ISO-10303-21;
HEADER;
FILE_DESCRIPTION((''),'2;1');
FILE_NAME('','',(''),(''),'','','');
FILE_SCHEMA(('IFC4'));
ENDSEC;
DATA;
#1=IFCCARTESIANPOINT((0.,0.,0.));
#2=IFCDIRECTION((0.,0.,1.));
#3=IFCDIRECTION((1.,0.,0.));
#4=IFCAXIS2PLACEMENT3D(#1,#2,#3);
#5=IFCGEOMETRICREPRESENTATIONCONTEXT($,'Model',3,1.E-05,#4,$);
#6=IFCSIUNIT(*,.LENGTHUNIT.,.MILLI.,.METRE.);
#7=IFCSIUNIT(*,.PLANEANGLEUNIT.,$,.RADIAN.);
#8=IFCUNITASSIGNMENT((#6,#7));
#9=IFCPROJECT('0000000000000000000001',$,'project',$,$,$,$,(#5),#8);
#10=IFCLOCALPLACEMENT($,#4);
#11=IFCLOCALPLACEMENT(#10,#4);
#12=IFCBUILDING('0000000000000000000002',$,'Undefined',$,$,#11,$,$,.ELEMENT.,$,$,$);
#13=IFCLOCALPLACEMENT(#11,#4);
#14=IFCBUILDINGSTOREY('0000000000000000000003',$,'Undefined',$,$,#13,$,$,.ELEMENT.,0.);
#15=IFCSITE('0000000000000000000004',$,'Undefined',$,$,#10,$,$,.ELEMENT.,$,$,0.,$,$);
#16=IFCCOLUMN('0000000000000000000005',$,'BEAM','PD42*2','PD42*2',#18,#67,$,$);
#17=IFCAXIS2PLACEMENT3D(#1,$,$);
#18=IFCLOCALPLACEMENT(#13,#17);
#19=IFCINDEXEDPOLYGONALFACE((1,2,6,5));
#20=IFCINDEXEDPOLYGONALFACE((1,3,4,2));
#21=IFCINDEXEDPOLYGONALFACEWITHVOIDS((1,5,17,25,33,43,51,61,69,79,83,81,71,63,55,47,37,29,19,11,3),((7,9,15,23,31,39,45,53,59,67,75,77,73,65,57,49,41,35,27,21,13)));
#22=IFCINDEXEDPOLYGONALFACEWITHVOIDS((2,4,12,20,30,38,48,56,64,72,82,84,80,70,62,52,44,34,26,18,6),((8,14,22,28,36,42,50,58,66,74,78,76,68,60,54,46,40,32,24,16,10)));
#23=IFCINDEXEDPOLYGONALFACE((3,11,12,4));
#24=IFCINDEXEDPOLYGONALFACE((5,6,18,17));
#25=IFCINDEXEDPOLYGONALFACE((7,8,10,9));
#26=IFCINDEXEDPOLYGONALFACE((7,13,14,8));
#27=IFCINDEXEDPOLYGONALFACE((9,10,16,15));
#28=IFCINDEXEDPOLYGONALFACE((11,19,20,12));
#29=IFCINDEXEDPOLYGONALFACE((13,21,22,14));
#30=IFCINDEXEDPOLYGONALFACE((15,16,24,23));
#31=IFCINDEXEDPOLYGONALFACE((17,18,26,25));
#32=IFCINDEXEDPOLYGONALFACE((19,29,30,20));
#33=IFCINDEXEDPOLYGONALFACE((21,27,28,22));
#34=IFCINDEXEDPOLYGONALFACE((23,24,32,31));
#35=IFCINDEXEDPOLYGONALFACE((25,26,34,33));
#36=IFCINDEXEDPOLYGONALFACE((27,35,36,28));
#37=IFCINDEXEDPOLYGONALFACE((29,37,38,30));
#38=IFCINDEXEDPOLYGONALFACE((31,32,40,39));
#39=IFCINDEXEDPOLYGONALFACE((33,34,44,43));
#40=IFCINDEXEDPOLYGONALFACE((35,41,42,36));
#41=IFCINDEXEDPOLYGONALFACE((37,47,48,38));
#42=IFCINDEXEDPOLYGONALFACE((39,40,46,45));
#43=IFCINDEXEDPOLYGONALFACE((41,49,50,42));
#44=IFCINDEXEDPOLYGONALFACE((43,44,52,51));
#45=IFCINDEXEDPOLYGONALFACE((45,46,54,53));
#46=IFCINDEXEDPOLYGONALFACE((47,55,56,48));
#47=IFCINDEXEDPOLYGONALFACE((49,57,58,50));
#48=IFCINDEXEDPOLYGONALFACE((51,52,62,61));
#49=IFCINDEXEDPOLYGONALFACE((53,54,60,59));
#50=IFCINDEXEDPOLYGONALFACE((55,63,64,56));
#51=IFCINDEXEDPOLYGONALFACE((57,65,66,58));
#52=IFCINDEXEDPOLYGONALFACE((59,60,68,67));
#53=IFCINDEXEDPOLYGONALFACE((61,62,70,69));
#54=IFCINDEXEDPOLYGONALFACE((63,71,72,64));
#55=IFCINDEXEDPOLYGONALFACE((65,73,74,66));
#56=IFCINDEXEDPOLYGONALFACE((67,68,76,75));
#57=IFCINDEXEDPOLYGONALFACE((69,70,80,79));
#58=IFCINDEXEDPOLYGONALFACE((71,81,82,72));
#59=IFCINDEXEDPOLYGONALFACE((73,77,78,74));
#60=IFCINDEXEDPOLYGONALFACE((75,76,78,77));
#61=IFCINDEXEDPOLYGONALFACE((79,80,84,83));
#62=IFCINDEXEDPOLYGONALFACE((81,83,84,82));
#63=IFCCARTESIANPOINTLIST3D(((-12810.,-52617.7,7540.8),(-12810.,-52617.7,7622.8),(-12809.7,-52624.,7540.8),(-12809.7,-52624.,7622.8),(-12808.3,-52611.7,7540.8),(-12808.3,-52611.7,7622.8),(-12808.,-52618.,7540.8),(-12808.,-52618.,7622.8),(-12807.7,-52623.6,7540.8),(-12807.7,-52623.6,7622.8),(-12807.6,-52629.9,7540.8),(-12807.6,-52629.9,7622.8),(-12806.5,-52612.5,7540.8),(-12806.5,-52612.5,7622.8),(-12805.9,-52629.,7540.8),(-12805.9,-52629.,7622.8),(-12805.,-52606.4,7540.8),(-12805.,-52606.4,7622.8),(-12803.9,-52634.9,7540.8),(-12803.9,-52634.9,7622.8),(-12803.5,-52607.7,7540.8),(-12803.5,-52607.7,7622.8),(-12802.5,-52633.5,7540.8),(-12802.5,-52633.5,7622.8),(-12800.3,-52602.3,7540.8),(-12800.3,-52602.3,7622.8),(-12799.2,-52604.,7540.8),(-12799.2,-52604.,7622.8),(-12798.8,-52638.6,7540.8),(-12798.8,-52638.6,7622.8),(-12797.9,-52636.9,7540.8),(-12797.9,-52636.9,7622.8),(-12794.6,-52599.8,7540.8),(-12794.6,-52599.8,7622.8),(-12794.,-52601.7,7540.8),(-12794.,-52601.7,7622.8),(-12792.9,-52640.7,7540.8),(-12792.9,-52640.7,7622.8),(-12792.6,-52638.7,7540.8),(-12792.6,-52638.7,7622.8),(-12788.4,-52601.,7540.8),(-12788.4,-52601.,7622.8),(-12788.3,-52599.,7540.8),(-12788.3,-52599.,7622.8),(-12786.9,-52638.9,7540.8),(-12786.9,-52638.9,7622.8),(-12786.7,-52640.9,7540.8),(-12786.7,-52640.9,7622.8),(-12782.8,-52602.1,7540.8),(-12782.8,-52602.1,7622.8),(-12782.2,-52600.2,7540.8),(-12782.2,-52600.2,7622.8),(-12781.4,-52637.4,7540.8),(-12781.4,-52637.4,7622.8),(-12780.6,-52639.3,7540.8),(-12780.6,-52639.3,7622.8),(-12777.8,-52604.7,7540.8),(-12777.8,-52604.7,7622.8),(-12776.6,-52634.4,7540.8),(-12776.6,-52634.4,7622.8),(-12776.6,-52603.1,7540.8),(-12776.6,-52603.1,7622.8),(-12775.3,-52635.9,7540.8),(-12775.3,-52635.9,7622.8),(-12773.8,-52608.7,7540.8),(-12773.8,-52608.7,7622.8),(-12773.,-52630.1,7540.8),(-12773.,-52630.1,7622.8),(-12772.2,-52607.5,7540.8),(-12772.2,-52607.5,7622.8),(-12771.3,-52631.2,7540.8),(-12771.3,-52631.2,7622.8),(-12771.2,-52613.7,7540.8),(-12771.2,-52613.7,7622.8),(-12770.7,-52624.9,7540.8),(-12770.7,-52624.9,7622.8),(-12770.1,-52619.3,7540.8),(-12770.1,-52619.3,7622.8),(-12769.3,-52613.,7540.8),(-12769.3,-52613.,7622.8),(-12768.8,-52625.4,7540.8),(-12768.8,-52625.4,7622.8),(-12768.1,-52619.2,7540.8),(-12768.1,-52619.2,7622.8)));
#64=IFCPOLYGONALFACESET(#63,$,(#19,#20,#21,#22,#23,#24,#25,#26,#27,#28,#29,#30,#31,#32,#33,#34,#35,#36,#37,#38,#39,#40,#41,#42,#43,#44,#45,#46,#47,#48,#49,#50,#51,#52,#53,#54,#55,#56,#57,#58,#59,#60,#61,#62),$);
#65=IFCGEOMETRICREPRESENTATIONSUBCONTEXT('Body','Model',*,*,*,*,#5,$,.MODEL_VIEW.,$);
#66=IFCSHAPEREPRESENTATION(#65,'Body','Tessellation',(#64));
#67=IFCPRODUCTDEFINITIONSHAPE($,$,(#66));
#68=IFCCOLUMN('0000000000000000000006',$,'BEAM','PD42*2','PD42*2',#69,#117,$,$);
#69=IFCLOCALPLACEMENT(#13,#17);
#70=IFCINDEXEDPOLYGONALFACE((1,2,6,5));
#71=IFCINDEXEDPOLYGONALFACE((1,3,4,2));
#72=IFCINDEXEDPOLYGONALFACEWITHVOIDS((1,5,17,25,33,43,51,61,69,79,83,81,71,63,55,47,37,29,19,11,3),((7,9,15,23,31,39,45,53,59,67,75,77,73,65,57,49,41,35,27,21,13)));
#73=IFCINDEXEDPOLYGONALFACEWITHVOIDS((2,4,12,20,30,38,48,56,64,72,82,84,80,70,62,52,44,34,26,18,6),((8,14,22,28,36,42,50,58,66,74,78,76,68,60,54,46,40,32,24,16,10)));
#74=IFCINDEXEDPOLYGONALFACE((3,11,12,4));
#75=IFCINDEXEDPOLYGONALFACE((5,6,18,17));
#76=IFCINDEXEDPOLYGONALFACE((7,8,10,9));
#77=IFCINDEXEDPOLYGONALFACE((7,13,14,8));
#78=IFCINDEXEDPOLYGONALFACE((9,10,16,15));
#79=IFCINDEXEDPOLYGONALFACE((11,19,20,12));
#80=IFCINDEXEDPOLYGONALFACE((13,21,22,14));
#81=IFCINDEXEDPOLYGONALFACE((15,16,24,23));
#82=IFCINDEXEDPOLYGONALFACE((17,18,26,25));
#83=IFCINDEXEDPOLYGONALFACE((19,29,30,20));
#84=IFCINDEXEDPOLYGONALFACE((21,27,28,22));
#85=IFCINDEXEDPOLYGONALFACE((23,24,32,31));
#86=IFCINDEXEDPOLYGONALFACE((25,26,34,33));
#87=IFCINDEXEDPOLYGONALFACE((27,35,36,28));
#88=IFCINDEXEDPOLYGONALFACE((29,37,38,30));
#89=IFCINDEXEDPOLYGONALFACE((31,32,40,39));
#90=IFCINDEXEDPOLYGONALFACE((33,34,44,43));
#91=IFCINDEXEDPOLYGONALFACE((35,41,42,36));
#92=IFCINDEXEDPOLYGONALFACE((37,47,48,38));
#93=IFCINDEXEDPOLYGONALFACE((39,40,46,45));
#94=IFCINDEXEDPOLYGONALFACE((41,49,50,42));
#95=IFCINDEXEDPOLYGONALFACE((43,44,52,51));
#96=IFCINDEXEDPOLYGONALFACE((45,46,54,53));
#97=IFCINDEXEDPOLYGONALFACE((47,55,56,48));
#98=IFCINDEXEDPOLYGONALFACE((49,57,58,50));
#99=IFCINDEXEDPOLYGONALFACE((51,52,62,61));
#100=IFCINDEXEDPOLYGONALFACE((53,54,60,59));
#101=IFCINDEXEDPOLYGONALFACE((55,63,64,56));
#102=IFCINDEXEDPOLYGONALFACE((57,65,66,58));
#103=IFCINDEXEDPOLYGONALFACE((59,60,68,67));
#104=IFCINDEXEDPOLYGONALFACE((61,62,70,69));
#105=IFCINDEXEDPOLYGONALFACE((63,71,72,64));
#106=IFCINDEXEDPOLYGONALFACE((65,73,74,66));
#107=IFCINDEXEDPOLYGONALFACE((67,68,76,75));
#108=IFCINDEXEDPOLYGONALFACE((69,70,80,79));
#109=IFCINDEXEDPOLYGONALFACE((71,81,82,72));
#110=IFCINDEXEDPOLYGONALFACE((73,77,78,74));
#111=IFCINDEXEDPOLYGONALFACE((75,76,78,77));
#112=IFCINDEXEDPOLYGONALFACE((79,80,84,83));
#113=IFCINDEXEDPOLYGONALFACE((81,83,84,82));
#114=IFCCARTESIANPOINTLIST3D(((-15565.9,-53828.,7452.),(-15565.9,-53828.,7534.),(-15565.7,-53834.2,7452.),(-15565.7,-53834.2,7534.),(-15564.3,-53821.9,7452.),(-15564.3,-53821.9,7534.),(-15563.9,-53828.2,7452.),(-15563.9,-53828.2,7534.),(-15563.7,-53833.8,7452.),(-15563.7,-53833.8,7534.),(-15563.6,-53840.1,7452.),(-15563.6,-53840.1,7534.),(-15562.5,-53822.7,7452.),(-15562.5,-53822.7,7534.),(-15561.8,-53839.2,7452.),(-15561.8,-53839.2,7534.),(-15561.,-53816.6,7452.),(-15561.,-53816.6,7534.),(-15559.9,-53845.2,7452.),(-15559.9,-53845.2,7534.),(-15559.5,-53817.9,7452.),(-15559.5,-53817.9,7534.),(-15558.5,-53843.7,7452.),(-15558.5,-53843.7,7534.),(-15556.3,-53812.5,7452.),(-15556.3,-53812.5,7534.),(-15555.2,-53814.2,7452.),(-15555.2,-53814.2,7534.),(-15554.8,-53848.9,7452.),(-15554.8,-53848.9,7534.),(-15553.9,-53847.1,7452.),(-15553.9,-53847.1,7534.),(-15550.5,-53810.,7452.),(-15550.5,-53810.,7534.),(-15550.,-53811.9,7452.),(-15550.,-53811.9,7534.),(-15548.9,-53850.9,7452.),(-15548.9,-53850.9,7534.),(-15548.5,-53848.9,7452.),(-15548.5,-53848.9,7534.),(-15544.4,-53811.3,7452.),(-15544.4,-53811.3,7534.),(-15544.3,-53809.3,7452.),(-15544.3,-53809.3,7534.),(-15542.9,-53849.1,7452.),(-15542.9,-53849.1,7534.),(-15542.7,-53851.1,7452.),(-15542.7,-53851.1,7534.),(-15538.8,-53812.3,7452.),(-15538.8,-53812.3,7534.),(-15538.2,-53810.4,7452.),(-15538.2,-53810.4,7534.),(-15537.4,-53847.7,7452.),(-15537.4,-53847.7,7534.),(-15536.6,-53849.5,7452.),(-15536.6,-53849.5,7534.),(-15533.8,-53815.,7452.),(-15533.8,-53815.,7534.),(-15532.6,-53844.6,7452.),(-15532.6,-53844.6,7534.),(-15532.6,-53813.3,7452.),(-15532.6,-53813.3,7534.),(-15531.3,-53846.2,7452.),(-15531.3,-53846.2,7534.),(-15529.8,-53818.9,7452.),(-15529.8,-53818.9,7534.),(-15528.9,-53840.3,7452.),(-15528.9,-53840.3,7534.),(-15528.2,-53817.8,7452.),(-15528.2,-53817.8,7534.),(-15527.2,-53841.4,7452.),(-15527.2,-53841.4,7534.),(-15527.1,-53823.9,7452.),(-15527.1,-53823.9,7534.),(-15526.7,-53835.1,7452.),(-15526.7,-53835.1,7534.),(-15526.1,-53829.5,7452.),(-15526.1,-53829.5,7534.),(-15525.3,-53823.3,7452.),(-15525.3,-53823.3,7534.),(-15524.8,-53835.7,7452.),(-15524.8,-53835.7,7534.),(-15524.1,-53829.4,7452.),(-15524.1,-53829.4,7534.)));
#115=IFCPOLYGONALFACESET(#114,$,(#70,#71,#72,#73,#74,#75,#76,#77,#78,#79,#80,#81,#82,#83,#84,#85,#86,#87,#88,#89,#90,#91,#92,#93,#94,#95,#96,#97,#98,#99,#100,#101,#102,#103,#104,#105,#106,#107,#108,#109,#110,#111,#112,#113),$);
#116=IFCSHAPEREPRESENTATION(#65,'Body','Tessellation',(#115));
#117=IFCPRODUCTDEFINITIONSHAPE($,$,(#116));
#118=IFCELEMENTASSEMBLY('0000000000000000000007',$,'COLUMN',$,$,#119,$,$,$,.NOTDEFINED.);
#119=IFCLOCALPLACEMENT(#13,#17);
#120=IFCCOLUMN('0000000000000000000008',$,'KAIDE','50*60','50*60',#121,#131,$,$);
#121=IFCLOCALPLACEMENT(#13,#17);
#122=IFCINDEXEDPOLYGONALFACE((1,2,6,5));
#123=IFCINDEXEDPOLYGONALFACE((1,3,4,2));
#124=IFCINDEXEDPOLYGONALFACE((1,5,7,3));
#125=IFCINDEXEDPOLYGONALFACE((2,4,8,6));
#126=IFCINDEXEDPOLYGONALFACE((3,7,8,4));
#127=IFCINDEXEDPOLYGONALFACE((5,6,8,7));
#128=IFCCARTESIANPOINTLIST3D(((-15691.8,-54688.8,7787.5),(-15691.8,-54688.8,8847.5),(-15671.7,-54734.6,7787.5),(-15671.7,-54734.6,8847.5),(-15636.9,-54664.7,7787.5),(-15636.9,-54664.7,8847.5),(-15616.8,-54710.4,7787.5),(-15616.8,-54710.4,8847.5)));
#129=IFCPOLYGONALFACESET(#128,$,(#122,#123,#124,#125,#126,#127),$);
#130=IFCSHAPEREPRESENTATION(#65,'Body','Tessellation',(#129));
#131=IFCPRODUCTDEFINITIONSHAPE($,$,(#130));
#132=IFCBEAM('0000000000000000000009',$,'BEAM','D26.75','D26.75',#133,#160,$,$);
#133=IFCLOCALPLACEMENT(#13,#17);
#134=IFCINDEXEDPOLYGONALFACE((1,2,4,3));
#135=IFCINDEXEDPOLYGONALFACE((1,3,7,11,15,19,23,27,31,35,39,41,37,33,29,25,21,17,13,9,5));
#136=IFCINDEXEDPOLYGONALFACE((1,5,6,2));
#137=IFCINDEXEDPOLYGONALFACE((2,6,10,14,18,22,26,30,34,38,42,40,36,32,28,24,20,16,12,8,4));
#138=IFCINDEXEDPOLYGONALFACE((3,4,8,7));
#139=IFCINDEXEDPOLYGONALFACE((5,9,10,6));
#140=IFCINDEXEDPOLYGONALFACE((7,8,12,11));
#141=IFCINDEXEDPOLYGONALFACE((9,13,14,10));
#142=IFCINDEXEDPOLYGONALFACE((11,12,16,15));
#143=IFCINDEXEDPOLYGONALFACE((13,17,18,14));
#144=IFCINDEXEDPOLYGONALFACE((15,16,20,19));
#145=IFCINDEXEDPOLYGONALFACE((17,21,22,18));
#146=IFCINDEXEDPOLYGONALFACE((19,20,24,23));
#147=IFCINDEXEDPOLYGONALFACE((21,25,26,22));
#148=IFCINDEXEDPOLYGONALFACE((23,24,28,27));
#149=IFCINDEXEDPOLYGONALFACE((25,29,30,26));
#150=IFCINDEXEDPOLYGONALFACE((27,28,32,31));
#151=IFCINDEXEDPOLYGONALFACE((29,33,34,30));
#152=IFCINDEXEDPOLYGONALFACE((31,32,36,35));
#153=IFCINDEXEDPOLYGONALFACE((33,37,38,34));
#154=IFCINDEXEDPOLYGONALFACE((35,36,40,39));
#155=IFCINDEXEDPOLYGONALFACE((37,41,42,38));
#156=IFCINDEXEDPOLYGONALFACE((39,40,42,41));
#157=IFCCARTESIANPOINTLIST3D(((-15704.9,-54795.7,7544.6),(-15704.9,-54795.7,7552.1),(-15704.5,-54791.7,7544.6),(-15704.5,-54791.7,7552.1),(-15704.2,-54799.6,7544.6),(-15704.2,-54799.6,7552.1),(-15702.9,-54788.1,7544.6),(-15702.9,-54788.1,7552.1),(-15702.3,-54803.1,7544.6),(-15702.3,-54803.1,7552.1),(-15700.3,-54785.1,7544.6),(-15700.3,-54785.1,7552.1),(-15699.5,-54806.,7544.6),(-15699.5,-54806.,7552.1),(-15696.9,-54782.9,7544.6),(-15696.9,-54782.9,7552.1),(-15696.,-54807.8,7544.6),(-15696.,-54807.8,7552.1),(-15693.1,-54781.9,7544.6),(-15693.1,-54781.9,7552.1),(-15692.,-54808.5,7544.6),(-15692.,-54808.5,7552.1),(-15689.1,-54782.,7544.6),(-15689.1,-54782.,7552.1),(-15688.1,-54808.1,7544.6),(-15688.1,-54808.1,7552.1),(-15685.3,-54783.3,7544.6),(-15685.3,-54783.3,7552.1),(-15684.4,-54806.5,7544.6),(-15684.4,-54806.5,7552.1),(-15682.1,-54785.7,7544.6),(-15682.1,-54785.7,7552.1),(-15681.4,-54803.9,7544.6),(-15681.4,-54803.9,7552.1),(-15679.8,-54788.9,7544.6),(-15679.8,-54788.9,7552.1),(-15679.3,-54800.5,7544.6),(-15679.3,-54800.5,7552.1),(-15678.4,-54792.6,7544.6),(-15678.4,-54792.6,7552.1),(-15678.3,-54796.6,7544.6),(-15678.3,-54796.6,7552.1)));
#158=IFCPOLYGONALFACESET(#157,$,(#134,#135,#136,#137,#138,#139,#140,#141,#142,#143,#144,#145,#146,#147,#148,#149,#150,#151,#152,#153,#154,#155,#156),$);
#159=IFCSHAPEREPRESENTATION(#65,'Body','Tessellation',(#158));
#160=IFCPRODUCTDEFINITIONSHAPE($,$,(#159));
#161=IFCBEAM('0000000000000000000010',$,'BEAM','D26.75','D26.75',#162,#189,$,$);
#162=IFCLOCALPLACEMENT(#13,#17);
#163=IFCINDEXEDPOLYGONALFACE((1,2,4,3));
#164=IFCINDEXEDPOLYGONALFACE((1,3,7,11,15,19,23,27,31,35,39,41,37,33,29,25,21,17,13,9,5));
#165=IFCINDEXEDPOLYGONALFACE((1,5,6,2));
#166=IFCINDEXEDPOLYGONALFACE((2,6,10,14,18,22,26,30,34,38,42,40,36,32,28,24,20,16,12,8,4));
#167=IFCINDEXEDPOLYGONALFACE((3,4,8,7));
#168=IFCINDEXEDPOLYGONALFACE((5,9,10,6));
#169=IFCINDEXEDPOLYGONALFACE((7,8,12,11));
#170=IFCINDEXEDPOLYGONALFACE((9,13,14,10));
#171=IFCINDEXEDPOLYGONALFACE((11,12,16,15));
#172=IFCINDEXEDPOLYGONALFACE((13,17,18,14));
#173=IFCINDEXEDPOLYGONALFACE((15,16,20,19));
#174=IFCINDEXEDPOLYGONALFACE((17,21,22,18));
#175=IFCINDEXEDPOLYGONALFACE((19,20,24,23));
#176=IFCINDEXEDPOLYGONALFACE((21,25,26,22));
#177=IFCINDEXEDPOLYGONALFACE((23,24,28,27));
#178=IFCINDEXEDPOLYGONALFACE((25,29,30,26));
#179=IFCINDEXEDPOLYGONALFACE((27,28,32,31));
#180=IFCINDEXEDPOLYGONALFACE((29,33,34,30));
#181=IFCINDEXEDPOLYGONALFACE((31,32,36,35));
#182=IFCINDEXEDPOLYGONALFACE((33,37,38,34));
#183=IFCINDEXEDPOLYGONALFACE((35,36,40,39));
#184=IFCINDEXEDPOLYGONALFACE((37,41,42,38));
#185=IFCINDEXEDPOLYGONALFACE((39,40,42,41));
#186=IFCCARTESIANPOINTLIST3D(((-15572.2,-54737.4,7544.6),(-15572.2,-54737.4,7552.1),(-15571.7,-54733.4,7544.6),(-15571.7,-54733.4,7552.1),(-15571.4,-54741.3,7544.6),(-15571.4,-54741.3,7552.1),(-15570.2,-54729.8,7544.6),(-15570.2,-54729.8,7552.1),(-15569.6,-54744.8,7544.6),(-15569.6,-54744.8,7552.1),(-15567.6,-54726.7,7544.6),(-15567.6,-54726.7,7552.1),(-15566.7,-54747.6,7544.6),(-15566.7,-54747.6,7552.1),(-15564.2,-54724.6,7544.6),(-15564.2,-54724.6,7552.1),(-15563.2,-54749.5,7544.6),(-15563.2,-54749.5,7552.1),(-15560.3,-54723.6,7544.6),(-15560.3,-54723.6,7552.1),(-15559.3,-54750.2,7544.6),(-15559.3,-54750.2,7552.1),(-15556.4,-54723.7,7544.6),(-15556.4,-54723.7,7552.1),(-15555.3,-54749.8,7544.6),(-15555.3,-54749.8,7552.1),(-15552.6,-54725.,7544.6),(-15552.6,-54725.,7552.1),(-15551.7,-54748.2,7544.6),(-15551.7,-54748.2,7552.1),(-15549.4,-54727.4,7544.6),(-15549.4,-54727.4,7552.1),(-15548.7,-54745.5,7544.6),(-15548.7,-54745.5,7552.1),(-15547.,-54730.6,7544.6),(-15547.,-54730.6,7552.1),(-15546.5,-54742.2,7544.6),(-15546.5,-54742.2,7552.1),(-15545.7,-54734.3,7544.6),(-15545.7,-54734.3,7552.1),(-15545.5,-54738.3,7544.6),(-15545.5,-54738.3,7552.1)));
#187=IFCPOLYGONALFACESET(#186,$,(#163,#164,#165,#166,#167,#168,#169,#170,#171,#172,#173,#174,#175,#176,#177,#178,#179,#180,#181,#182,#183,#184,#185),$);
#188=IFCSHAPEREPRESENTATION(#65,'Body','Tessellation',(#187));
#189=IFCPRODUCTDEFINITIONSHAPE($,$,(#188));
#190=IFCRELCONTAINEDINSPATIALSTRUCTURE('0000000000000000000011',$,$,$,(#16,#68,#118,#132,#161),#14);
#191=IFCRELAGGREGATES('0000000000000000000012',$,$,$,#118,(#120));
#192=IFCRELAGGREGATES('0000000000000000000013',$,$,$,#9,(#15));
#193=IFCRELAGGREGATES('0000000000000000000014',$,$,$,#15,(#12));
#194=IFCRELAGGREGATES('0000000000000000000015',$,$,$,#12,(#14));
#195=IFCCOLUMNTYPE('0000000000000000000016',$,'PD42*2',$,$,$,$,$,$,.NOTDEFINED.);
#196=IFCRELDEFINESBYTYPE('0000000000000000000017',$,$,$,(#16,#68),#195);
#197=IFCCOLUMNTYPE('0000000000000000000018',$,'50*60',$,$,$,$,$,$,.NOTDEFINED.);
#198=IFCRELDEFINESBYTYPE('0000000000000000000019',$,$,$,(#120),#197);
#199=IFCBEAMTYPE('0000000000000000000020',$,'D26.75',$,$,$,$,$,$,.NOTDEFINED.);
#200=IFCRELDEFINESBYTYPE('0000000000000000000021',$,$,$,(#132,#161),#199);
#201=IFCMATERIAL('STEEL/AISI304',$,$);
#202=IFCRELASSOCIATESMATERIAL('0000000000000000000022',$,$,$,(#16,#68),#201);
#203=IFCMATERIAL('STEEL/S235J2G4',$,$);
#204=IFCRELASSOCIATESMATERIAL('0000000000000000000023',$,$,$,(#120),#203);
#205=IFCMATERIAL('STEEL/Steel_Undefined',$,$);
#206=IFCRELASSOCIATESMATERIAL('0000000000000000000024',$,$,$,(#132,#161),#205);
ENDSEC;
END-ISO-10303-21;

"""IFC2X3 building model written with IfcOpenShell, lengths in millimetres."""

from ifc_helpers import new_model, si_unit, frame, origin_with_axes, origin_2d_with_axis, place, context, subcontext, project, spatial, rectangle, circle, hollow_circle, extrude, material, type_object, element, aggregate, save


model = new_model("IFC2X3")

# Units and contexts
model_context = context("Model", 3, precision=1e-05, world=origin_with_axes())
body_context = subcontext(model_context, "Body", "Model", "MODEL_VIEW")
ifc_project = project(units=[si_unit("LENGTHUNIT", "METRE", prefix="MILLI"), si_unit("PLANEANGLEUNIT", "RADIAN")], contexts=[model_context])

# Site, building, storey
site_placement = place(None, origin_with_axes())
site = spatial("IfcSite", under=ifc_project, at=site_placement, Name="Undefined", CompositionType="ELEMENT", RefElevation=0.0)
building_placement = place(site_placement, origin_with_axes())
building = spatial("IfcBuilding", under=site, at=building_placement, Name="Undefined", CompositionType="ELEMENT")
storey_placement = place(building_placement, origin_with_axes())
storey = spatial("IfcBuildingStorey", under=building, at=storey_placement, Name="Undefined", CompositionType="ELEMENT", Elevation=0.0)

# Columns
ifc_material_1 = material(Name="STEEL/AISI304")
column_type_1 = type_object("IfcColumnType", Name="PD42*2", PredefinedType="NOTDEFINED")
for number, where, z_axis, x_axis, name in (
    (1, (-12789.1, -52620.0, 7540.8), (0.0, 0.0, 1.0), (1.0, 0.0, 0.0), "BEAM"),
    (2, (-15545.1, -53830.3, 7452.0), (0.0, 0.0, 1.0), (1.0, 0.0, 0.0), "BEAM"),
):
    element("IfcColumn", number, at=place(storey_placement, frame(where, z_axis=z_axis, x_axis=x_axis)), inside=storey, type_object=column_type_1, material=ifc_material_1, Name=name, Description="PD42*2", ObjectType="PD42*2", context=body_context, shape_type="SweptSolid", body=[
        extrude(hollow_circle(Radius=21.0, WallThickness=2.0, at=origin_2d_with_axis()), frame((0.0, 0.0, 82.0), z_axis=(0.0, 0.0, -1.0), x_axis=(0.402197, -0.915553, 0.0)), (0.0, 0.0, 1.0), 82.0),
    ])

# Element assembly, column
assembly_placement = place(storey_placement, frame((-15654.3, -54699.6, 7787.5), z_axis=(-0.402198, 0.915553, 0.0), x_axis=(0.0, 0.0, 1.0)))
assembly = element("IfcElementAssembly", 3, at=assembly_placement, inside=storey, Name="COLUMN", PredefinedType="NOTDEFINED")
ifc_material_2 = material(Name="STEEL/S235J2G4")
column_type_2 = type_object("IfcColumnType", Name="50*60", PredefinedType="NOTDEFINED")
column_placement = place(storey_placement, frame((-15654.3, -54699.6, 7787.5), z_axis=(0.0, 0.0, 1.0), x_axis=(1.0, 0.0, 0.0)))
column = element("IfcColumn", 4, at=column_placement, type_object=column_type_2, material=ifc_material_2, Name="KAIDE", Description="50*60", ObjectType="50*60", context=body_context, shape_type="SweptSolid", body=[
    extrude(rectangle(XDim=60.0, YDim=50.0, at=origin_2d_with_axis()), frame((0.0, 0.0, 1060.0), z_axis=(0.0, 0.0, -1.0), x_axis=(-0.915553, -0.402197, 0.0)), (0.0, 0.0, 1.0), 1060.0),
])
aggregate(assembly, [column])

# Beam
ifc_material_3 = material(Name="STEEL/Steel_Undefined")
beam_type_1 = type_object("IfcBeamType", Name="D26.75", PredefinedType="NOTDEFINED")
beam_1_placement = place(storey_placement, frame((-15691.6, -54795.2, 7552.1), z_axis=(-0.915553, -0.402197, 0.0), x_axis=(0.0, 0.0, -1.0)))
element("IfcBeam", 5, at=beam_1_placement, inside=storey, type_object=beam_type_1, material=ifc_material_3, Name="BEAM", Description="D26.75", ObjectType="D26.75", context=body_context, shape_type="SweptSolid", body=[
    extrude(circle(Radius=13.4, at=origin_2d_with_axis()), frame((7.4, 0.0, 0.0), z_axis=(-1.0, 0.0, 0.0), x_axis=(0.0, -1.0, 0.0)), (0.0, 0.0, 1.0), 7.4),
])

# Beam
beam_2_placement = place(storey_placement, frame((-15558.8, -54736.9, 7552.1), z_axis=(-0.915553, -0.402197, 0.0), x_axis=(0.0, 0.0, -1.0)))
element("IfcBeam", 6, at=beam_2_placement, inside=storey, type_object=beam_type_1, material=ifc_material_3, Name="BEAM", Description="D26.75", ObjectType="D26.75", context=body_context, shape_type="SweptSolid", body=[
    extrude(circle(Radius=13.4, at=origin_2d_with_axis()), frame((7.4, 0.0, 0.0), z_axis=(-1.0, 0.0, 0.0), x_axis=(0.0, -1.0, 0.0)), (0.0, 0.0, 1.0), 7.4),
])

save(model, "model.ifc")
